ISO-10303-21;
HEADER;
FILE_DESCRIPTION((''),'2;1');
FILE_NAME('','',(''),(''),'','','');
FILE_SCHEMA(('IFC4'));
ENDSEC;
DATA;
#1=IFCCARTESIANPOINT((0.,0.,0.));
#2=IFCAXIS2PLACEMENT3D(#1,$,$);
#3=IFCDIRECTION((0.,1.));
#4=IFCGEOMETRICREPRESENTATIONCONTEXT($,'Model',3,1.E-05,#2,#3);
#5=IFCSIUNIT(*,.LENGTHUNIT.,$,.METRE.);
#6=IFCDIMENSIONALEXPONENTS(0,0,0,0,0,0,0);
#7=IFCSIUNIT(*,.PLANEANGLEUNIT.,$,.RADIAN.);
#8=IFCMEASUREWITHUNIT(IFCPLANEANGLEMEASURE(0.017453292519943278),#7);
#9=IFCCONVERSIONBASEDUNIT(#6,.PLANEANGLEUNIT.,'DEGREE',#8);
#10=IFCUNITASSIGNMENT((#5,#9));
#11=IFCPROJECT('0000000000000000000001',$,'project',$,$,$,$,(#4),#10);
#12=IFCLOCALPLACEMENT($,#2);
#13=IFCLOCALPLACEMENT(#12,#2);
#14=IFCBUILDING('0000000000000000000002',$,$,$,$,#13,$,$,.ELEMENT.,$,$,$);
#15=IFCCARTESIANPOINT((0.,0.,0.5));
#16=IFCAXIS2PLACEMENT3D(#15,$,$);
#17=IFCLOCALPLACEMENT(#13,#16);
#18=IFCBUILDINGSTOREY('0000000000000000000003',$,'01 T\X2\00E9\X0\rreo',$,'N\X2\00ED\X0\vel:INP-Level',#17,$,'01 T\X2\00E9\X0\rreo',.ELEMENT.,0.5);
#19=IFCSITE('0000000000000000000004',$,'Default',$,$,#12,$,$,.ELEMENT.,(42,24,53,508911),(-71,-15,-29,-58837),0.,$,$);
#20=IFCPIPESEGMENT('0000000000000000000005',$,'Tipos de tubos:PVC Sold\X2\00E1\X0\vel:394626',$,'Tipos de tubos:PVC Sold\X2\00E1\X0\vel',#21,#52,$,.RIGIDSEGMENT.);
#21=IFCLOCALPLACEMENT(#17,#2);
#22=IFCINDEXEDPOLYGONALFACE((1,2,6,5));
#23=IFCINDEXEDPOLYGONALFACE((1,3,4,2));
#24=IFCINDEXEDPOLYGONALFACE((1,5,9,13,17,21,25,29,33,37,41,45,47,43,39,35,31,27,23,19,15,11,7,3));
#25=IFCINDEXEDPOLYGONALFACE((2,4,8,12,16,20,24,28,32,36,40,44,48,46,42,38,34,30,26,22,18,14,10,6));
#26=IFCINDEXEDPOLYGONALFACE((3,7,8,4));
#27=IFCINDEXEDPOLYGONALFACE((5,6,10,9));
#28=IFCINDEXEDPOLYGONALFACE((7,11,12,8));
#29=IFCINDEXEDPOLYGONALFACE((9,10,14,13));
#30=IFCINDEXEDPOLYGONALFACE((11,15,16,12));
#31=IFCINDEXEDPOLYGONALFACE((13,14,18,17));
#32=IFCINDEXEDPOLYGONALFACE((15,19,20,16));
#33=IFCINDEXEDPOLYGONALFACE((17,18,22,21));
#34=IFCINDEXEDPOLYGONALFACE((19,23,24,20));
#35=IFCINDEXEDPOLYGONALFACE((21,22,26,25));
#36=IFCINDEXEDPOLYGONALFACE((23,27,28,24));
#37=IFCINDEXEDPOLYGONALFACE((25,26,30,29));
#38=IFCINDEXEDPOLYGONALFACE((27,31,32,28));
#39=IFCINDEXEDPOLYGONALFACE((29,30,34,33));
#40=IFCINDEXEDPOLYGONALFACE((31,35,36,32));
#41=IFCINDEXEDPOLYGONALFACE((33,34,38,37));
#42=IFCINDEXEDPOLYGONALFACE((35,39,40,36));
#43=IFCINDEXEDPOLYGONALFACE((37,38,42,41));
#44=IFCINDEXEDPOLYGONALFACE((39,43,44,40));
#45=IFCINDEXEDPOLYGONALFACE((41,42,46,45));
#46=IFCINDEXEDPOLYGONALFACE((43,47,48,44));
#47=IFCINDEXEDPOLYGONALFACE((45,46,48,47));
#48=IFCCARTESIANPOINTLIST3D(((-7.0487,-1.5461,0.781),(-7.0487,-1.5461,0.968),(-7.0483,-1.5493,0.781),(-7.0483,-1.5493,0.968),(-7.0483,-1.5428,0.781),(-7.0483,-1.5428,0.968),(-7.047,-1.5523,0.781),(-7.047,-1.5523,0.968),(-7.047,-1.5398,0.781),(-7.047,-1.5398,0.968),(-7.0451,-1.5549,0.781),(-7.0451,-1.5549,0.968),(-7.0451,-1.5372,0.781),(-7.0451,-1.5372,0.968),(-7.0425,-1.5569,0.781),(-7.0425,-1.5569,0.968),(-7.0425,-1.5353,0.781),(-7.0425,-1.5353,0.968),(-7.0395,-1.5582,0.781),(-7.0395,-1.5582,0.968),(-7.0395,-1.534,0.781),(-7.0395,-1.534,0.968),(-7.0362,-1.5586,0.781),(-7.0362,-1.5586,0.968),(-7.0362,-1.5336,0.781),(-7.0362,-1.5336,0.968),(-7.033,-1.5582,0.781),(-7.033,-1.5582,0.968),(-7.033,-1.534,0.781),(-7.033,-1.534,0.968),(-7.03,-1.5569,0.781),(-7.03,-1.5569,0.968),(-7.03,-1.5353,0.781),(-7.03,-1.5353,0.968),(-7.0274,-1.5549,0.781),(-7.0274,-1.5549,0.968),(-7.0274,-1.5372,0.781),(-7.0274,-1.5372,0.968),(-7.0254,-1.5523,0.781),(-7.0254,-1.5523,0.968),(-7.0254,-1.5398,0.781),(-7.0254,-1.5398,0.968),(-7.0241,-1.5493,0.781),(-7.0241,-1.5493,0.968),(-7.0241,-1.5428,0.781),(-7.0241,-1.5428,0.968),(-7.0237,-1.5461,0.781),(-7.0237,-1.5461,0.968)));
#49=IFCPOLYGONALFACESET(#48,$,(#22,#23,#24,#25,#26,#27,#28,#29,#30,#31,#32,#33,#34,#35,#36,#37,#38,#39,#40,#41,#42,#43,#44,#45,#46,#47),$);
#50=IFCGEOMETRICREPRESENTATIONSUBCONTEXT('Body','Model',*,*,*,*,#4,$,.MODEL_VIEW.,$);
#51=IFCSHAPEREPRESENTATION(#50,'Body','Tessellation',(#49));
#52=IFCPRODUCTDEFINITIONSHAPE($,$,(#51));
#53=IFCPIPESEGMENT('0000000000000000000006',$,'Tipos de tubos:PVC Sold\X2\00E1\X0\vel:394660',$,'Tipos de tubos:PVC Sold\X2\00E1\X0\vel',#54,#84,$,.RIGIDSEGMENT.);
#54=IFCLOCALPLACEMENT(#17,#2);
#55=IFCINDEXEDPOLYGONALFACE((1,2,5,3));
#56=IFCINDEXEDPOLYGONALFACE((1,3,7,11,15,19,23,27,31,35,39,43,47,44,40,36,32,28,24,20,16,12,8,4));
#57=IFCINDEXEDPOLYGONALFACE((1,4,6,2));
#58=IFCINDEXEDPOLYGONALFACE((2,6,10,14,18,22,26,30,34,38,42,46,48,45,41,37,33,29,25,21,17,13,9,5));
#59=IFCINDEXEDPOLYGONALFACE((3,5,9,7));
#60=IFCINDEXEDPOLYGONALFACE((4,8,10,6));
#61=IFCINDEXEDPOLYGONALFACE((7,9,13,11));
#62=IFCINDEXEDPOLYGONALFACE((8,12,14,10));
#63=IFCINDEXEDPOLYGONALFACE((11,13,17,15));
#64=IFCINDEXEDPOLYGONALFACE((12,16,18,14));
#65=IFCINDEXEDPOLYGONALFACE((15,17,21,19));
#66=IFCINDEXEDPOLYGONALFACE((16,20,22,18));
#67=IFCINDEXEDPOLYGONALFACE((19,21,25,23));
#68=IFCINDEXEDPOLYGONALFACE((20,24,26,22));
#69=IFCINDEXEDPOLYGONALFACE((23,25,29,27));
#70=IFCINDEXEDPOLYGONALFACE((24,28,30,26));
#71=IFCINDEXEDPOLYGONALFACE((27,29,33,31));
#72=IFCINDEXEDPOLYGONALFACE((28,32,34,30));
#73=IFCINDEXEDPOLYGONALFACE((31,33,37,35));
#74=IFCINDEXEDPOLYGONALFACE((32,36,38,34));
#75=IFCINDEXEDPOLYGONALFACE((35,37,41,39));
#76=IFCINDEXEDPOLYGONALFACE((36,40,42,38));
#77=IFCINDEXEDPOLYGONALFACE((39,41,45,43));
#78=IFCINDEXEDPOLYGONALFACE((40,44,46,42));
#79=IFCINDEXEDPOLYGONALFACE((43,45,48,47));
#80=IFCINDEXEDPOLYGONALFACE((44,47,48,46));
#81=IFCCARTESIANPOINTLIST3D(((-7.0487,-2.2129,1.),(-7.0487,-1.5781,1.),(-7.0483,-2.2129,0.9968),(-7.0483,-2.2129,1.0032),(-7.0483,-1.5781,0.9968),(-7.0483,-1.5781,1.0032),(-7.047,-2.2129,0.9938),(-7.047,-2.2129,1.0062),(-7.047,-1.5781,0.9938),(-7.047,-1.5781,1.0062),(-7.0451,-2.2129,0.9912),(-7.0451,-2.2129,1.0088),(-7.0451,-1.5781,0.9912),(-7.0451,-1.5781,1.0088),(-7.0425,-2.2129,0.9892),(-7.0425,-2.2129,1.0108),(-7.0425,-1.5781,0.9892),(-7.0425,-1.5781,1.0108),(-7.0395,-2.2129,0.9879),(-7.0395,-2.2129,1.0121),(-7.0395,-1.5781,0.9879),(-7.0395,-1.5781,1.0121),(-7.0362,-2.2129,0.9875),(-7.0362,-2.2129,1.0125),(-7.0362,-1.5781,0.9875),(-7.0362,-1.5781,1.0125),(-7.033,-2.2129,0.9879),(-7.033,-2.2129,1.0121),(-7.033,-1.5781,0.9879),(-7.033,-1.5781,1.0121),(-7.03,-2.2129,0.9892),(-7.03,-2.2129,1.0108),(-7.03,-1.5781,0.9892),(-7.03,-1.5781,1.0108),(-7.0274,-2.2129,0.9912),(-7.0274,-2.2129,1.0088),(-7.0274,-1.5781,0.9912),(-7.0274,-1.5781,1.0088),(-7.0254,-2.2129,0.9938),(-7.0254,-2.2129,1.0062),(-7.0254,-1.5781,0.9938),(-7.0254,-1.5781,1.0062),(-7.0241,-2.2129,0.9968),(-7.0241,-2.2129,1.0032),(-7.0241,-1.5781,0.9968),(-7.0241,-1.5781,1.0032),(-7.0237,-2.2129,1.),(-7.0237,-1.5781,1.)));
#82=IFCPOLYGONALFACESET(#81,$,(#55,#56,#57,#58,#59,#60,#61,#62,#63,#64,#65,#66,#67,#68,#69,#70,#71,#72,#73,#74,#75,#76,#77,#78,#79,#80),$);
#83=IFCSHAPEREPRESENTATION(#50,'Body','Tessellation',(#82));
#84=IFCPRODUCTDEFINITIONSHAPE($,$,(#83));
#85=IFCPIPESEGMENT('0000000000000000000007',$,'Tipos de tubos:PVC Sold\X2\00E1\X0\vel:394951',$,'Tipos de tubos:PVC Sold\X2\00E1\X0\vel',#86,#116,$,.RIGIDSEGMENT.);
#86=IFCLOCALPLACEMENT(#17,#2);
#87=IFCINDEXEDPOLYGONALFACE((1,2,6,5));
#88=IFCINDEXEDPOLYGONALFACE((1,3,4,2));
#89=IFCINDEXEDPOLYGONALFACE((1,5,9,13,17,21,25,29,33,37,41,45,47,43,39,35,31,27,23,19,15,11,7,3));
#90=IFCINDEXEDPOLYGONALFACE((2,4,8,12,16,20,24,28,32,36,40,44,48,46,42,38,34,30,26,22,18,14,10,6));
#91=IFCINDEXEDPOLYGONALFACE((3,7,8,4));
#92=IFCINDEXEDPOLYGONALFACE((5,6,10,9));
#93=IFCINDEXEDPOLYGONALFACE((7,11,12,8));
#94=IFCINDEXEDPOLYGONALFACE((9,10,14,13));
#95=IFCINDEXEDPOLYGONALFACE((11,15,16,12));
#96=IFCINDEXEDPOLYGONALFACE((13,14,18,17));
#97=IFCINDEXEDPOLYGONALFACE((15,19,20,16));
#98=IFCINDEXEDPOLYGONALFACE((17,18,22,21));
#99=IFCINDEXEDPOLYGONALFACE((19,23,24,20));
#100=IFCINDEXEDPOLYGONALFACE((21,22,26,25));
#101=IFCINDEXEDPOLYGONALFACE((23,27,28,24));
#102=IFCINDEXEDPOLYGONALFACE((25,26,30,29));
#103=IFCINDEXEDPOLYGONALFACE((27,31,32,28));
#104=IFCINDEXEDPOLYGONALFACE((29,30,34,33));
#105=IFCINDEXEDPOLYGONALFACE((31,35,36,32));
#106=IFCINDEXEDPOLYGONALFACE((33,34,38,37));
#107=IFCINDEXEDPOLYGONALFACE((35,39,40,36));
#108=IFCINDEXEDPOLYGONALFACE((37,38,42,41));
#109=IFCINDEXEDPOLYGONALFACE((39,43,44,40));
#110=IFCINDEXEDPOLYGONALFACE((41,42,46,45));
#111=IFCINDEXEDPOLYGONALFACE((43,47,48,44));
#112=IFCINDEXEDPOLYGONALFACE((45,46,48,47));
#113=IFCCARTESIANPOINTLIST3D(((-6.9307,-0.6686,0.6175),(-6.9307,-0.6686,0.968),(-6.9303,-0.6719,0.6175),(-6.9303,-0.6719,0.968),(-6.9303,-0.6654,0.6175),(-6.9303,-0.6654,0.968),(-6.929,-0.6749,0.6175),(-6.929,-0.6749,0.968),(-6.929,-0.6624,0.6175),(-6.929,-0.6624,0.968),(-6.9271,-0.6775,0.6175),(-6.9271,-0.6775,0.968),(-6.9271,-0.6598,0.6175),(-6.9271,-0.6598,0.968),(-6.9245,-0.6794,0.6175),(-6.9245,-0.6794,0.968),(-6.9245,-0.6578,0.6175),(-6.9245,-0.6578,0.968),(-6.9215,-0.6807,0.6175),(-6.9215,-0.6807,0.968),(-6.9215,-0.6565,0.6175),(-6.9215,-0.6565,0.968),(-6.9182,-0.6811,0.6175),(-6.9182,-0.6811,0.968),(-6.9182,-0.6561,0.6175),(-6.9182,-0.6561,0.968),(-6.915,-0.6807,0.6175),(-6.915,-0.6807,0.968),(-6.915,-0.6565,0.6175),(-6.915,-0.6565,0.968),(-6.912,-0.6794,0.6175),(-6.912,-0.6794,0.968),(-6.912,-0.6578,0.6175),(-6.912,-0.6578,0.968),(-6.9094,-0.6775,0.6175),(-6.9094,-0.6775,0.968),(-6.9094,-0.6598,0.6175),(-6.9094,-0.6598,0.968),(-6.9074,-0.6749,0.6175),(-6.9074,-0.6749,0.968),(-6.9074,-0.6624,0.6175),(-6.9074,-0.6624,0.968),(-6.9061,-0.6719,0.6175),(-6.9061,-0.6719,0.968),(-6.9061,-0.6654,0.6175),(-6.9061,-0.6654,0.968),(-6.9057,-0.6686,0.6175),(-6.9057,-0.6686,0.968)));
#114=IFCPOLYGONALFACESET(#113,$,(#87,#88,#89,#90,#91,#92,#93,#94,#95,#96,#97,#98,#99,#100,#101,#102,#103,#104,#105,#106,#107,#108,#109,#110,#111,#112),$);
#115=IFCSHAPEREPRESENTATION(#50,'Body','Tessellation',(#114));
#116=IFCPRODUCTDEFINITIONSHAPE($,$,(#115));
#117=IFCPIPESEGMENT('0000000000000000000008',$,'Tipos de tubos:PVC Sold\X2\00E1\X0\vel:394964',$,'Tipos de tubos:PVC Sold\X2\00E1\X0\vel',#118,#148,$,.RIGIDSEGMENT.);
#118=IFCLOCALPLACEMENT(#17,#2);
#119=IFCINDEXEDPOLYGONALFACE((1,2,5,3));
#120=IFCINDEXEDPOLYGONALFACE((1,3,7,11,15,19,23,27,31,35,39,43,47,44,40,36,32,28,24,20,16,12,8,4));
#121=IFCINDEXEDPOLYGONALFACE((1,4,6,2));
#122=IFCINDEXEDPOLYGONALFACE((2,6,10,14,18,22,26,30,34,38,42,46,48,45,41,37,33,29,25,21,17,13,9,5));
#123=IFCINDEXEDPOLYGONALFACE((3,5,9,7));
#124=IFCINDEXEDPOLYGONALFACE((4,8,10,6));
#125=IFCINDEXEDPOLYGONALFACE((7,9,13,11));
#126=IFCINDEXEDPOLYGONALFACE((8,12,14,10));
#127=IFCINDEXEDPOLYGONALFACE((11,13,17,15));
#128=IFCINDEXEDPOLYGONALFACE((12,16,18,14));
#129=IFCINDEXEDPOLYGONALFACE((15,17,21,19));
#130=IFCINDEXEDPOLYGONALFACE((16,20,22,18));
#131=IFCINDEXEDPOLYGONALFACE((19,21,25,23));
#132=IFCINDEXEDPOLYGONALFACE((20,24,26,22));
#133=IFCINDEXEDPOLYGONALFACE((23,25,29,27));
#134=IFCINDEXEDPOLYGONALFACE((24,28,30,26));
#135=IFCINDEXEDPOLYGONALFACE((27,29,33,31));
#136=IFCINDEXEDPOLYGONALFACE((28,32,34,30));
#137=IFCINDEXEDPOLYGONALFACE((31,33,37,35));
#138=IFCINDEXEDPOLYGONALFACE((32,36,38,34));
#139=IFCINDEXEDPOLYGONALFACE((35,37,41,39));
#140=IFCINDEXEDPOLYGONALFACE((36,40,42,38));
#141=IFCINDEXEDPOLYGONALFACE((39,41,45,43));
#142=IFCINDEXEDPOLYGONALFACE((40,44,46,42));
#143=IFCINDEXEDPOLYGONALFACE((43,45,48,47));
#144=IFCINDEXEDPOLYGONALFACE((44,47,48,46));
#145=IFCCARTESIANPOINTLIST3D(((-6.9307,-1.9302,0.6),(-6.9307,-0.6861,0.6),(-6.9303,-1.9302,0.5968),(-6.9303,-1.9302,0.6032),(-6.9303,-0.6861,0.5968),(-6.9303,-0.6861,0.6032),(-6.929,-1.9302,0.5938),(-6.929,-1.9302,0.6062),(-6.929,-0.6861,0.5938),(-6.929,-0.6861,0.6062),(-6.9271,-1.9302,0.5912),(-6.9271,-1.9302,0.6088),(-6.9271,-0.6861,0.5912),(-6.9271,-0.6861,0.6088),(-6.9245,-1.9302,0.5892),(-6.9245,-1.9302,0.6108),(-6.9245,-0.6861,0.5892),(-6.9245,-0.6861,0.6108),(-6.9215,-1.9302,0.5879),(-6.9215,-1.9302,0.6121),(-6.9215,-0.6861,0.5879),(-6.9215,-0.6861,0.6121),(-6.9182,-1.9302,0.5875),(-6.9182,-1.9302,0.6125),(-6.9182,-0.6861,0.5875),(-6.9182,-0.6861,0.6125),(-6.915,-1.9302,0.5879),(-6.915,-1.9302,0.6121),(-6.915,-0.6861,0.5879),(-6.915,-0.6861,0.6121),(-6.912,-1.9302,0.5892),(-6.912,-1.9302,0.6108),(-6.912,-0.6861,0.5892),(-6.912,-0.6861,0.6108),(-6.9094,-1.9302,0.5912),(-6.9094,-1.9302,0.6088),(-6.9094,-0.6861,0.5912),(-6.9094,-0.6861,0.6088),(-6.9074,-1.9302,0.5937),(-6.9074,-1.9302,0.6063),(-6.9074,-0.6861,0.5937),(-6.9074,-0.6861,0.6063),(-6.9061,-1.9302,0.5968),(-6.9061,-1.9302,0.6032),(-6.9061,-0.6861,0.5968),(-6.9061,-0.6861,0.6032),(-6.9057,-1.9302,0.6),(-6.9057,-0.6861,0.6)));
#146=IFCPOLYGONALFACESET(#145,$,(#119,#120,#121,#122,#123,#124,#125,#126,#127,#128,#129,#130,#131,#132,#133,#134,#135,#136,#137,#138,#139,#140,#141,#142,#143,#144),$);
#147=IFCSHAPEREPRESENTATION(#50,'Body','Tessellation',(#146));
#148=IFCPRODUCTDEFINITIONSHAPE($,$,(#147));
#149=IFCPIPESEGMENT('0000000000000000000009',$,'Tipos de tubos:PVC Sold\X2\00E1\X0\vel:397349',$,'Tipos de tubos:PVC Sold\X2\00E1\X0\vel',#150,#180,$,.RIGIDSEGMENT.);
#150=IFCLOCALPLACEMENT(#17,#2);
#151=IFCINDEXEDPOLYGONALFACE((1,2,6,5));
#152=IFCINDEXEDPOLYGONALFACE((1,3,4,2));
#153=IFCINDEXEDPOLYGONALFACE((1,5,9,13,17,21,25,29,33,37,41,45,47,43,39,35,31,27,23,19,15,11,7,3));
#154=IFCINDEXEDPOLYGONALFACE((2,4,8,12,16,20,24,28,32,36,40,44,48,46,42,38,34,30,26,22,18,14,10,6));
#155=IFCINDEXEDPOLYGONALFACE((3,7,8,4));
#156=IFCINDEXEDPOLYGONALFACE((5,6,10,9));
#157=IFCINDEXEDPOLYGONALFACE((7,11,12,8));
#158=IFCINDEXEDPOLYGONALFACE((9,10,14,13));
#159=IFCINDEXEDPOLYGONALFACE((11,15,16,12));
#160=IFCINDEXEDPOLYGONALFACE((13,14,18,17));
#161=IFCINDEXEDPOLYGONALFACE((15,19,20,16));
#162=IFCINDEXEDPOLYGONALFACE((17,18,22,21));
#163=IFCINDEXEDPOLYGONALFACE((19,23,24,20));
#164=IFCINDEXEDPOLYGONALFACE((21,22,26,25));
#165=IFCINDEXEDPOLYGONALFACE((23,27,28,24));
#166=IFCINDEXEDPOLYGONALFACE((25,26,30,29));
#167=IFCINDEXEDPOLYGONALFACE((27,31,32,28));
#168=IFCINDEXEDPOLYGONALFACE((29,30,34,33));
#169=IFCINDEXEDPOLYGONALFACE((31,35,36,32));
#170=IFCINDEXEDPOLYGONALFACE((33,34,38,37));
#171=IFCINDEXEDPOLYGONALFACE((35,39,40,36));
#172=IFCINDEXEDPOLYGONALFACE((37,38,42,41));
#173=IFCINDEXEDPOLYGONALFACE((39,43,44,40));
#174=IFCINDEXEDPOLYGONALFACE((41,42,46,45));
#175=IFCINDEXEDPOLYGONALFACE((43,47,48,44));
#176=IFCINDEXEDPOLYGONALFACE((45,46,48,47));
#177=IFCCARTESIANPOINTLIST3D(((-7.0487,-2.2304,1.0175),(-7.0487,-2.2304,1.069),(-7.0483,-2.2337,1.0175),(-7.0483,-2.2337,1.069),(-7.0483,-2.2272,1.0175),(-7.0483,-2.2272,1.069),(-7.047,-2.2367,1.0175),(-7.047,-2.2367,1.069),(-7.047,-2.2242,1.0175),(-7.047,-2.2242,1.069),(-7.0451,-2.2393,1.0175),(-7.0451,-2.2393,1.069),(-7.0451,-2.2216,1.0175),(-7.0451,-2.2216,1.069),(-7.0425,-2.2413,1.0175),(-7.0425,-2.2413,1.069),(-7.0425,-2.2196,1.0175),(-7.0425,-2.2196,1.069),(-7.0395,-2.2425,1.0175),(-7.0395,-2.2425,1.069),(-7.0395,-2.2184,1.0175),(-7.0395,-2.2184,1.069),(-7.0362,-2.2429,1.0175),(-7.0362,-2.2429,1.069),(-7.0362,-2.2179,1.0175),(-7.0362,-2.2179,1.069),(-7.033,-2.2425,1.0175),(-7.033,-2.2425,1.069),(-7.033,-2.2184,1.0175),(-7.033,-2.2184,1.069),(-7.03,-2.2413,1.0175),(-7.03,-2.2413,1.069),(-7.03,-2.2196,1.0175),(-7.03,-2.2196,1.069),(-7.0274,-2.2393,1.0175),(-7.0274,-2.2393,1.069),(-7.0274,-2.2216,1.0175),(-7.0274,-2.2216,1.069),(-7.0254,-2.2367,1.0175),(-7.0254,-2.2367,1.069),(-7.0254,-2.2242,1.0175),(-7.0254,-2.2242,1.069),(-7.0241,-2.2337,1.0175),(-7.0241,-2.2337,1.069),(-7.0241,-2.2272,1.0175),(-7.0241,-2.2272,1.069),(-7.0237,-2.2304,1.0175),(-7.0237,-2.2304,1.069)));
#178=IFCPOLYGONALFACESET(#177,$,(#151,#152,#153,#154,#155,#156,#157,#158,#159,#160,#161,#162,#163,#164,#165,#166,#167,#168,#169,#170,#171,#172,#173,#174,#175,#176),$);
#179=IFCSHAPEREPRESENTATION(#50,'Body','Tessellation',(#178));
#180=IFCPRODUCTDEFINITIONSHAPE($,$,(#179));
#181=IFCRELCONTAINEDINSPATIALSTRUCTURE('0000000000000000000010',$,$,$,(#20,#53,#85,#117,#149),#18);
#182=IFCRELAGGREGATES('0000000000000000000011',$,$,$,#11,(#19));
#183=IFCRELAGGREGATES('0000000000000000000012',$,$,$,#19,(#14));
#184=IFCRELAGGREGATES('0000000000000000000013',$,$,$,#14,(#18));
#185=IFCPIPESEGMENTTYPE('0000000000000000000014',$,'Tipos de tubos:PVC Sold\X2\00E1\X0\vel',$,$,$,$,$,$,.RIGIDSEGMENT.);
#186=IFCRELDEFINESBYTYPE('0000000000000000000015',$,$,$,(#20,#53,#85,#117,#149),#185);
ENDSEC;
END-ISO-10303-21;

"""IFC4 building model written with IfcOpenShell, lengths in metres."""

from ifc_helpers import new_model, entity, si_unit, converted_unit, direction, frame, origin, place, context, subcontext, project, spatial, arc, indexed_curve, outline, extrude, type_object, element, save


model = new_model("IFC4")

# Units and contexts
model_context = context("Model", 3, precision=1e-05, world=origin(), true_north=direction((0.0, 1.0)))
body_context = subcontext(model_context, "Body", "Model", "MODEL_VIEW")
ifc_project = project(units=[si_unit("LENGTHUNIT", "METRE"), converted_unit("PLANEANGLEUNIT", "DEGREE", entity("IfcPlaneAngleMeasure", 0.017453292519943278), si_unit("PLANEANGLEUNIT", "RADIAN"), dimensions=[0, 0, 0, 0, 0, 0, 0])], contexts=[model_context])

# Site, building, storey
site_placement = place(None, origin())
site = spatial("IfcSite", under=ifc_project, at=site_placement, Name="Default", CompositionType="ELEMENT", RefLatitude=(42, 24, 53, 508911), RefLongitude=(-71, -15, -29, -58837), RefElevation=0.0)
building_placement = place(site_placement, origin())
building = spatial("IfcBuilding", under=site, at=building_placement, CompositionType="ELEMENT")
storey_placement = place(building_placement, frame((0.0, 0.0, 0.5)))
storey = spatial("IfcBuildingStorey", under=building, at=storey_placement, Name="01 Térreo", ObjectType="Nível:INP-Level", LongName="01 Térreo", CompositionType="ELEMENT", Elevation=0.5)

# Pipe segments
pipe_segment_type = type_object("IfcPipeSegmentType", Name="Tipos de tubos:PVC Soldável", PredefinedType="RIGIDSEGMENT")
pipe_segment_1_placement = place(storey_placement, origin())
element("IfcPipeSegment", 1, at=pipe_segment_1_placement, inside=storey, type_object=pipe_segment_type, Name="Tipos de tubos:PVC Soldável:394626", ObjectType="Tipos de tubos:PVC Soldável", PredefinedType="RIGIDSEGMENT", context=body_context, shape_type="SweptSolid", body=[
    extrude(outline(indexed_curve([(0.0125, 0.0), (0.0088, 0.0088), (0.0, 0.0125), (-0.0088, 0.0088), (-0.0125, 0.0), (-0.0088, -0.0088), (0.0, -0.0125), (0.0088, -0.0088)], segments=[arc(1, 2, 3), arc(3, 4, 5), arc(5, 6, 7), arc(7, 8, 1)], self_intersect=False)), frame((-7.0362, -1.5461, 0.781)), (0.0, 0.0, 1.0), 0.187),
])
pipe_segment_2_placement = place(storey_placement, origin())
element("IfcPipeSegment", 2, at=pipe_segment_2_placement, inside=storey, type_object=pipe_segment_type, Name="Tipos de tubos:PVC Soldável:394660", ObjectType="Tipos de tubos:PVC Soldável", PredefinedType="RIGIDSEGMENT", context=body_context, shape_type="SweptSolid", body=[
    extrude(outline(indexed_curve([(0.0125, 0.0), (0.0088, 0.0088), (0.0, 0.0125), (-0.0088, 0.0088), (-0.0125, 0.0), (-0.0088, -0.0088), (0.0, -0.0125), (0.0088, -0.0088)], segments=[arc(1, 2, 3), arc(3, 4, 5), arc(5, 6, 7), arc(7, 8, 1)], self_intersect=False)), frame((-7.0362, -2.2129, 1.0), z_axis=(0.0, 1.0, 0.0), x_axis=(-1.0, 0.0, 0.0)), (0.0, 0.0, 1.0), 0.6349),
])
pipe_segment_3_placement = place(storey_placement, origin())
element("IfcPipeSegment", 3, at=pipe_segment_3_placement, inside=storey, type_object=pipe_segment_type, Name="Tipos de tubos:PVC Soldável:394951", ObjectType="Tipos de tubos:PVC Soldável", PredefinedType="RIGIDSEGMENT", context=body_context, shape_type="SweptSolid", body=[
    extrude(outline(indexed_curve([(0.0125, 0.0), (0.0088, 0.0088), (0.0, 0.0125), (-0.0088, 0.0088), (-0.0125, 0.0), (-0.0088, -0.0088), (0.0, -0.0125), (0.0088, -0.0088)], segments=[arc(1, 2, 3), arc(3, 4, 5), arc(5, 6, 7), arc(7, 8, 1)], self_intersect=False)), frame((-6.9182, -0.6686, 0.6175)), (0.0, 0.0, 1.0), 0.3505),
])
pipe_segment_4_placement = place(storey_placement, origin())
element("IfcPipeSegment", 4, at=pipe_segment_4_placement, inside=storey, type_object=pipe_segment_type, Name="Tipos de tubos:PVC Soldável:394964", ObjectType="Tipos de tubos:PVC Soldável", PredefinedType="RIGIDSEGMENT", context=body_context, shape_type="SweptSolid", body=[
    extrude(outline(indexed_curve([(0.0125, 0.0), (0.0088, 0.0088), (0.0, 0.0125), (-0.0088, 0.0088), (-0.0125, 0.0), (-0.0088, -0.0088), (0.0, -0.0125), (0.0088, -0.0088)], segments=[arc(1, 2, 3), arc(3, 4, 5), arc(5, 6, 7), arc(7, 8, 1)], self_intersect=False)), frame((-6.9182, -1.9302, 0.6), z_axis=(0.0, 1.0, 0.0), x_axis=(-1.0, 0.0, 0.0)), (0.0, 0.0, 1.0), 1.2441),
])
pipe_segment_5_placement = place(storey_placement, origin())
element("IfcPipeSegment", 5, at=pipe_segment_5_placement, inside=storey, type_object=pipe_segment_type, Name="Tipos de tubos:PVC Soldável:397349", ObjectType="Tipos de tubos:PVC Soldável", PredefinedType="RIGIDSEGMENT", context=body_context, shape_type="SweptSolid", body=[
    extrude(outline(indexed_curve([(0.0125, 0.0), (0.0088, 0.0088), (0.0, 0.0125), (-0.0088, 0.0088), (-0.0125, 0.0), (-0.0088, -0.0088), (0.0, -0.0125), (0.0088, -0.0088)], segments=[arc(1, 2, 3), arc(3, 4, 5), arc(5, 6, 7), arc(7, 8, 1)], self_intersect=False)), frame((-7.0362, -2.2304, 1.0175), z_axis=(0.0, 0.0, 1.0), x_axis=(-1.0, 0.0, 0.0)), (0.0, 0.0, 1.0), 0.0515),
])

save(model, "model.ifc")
